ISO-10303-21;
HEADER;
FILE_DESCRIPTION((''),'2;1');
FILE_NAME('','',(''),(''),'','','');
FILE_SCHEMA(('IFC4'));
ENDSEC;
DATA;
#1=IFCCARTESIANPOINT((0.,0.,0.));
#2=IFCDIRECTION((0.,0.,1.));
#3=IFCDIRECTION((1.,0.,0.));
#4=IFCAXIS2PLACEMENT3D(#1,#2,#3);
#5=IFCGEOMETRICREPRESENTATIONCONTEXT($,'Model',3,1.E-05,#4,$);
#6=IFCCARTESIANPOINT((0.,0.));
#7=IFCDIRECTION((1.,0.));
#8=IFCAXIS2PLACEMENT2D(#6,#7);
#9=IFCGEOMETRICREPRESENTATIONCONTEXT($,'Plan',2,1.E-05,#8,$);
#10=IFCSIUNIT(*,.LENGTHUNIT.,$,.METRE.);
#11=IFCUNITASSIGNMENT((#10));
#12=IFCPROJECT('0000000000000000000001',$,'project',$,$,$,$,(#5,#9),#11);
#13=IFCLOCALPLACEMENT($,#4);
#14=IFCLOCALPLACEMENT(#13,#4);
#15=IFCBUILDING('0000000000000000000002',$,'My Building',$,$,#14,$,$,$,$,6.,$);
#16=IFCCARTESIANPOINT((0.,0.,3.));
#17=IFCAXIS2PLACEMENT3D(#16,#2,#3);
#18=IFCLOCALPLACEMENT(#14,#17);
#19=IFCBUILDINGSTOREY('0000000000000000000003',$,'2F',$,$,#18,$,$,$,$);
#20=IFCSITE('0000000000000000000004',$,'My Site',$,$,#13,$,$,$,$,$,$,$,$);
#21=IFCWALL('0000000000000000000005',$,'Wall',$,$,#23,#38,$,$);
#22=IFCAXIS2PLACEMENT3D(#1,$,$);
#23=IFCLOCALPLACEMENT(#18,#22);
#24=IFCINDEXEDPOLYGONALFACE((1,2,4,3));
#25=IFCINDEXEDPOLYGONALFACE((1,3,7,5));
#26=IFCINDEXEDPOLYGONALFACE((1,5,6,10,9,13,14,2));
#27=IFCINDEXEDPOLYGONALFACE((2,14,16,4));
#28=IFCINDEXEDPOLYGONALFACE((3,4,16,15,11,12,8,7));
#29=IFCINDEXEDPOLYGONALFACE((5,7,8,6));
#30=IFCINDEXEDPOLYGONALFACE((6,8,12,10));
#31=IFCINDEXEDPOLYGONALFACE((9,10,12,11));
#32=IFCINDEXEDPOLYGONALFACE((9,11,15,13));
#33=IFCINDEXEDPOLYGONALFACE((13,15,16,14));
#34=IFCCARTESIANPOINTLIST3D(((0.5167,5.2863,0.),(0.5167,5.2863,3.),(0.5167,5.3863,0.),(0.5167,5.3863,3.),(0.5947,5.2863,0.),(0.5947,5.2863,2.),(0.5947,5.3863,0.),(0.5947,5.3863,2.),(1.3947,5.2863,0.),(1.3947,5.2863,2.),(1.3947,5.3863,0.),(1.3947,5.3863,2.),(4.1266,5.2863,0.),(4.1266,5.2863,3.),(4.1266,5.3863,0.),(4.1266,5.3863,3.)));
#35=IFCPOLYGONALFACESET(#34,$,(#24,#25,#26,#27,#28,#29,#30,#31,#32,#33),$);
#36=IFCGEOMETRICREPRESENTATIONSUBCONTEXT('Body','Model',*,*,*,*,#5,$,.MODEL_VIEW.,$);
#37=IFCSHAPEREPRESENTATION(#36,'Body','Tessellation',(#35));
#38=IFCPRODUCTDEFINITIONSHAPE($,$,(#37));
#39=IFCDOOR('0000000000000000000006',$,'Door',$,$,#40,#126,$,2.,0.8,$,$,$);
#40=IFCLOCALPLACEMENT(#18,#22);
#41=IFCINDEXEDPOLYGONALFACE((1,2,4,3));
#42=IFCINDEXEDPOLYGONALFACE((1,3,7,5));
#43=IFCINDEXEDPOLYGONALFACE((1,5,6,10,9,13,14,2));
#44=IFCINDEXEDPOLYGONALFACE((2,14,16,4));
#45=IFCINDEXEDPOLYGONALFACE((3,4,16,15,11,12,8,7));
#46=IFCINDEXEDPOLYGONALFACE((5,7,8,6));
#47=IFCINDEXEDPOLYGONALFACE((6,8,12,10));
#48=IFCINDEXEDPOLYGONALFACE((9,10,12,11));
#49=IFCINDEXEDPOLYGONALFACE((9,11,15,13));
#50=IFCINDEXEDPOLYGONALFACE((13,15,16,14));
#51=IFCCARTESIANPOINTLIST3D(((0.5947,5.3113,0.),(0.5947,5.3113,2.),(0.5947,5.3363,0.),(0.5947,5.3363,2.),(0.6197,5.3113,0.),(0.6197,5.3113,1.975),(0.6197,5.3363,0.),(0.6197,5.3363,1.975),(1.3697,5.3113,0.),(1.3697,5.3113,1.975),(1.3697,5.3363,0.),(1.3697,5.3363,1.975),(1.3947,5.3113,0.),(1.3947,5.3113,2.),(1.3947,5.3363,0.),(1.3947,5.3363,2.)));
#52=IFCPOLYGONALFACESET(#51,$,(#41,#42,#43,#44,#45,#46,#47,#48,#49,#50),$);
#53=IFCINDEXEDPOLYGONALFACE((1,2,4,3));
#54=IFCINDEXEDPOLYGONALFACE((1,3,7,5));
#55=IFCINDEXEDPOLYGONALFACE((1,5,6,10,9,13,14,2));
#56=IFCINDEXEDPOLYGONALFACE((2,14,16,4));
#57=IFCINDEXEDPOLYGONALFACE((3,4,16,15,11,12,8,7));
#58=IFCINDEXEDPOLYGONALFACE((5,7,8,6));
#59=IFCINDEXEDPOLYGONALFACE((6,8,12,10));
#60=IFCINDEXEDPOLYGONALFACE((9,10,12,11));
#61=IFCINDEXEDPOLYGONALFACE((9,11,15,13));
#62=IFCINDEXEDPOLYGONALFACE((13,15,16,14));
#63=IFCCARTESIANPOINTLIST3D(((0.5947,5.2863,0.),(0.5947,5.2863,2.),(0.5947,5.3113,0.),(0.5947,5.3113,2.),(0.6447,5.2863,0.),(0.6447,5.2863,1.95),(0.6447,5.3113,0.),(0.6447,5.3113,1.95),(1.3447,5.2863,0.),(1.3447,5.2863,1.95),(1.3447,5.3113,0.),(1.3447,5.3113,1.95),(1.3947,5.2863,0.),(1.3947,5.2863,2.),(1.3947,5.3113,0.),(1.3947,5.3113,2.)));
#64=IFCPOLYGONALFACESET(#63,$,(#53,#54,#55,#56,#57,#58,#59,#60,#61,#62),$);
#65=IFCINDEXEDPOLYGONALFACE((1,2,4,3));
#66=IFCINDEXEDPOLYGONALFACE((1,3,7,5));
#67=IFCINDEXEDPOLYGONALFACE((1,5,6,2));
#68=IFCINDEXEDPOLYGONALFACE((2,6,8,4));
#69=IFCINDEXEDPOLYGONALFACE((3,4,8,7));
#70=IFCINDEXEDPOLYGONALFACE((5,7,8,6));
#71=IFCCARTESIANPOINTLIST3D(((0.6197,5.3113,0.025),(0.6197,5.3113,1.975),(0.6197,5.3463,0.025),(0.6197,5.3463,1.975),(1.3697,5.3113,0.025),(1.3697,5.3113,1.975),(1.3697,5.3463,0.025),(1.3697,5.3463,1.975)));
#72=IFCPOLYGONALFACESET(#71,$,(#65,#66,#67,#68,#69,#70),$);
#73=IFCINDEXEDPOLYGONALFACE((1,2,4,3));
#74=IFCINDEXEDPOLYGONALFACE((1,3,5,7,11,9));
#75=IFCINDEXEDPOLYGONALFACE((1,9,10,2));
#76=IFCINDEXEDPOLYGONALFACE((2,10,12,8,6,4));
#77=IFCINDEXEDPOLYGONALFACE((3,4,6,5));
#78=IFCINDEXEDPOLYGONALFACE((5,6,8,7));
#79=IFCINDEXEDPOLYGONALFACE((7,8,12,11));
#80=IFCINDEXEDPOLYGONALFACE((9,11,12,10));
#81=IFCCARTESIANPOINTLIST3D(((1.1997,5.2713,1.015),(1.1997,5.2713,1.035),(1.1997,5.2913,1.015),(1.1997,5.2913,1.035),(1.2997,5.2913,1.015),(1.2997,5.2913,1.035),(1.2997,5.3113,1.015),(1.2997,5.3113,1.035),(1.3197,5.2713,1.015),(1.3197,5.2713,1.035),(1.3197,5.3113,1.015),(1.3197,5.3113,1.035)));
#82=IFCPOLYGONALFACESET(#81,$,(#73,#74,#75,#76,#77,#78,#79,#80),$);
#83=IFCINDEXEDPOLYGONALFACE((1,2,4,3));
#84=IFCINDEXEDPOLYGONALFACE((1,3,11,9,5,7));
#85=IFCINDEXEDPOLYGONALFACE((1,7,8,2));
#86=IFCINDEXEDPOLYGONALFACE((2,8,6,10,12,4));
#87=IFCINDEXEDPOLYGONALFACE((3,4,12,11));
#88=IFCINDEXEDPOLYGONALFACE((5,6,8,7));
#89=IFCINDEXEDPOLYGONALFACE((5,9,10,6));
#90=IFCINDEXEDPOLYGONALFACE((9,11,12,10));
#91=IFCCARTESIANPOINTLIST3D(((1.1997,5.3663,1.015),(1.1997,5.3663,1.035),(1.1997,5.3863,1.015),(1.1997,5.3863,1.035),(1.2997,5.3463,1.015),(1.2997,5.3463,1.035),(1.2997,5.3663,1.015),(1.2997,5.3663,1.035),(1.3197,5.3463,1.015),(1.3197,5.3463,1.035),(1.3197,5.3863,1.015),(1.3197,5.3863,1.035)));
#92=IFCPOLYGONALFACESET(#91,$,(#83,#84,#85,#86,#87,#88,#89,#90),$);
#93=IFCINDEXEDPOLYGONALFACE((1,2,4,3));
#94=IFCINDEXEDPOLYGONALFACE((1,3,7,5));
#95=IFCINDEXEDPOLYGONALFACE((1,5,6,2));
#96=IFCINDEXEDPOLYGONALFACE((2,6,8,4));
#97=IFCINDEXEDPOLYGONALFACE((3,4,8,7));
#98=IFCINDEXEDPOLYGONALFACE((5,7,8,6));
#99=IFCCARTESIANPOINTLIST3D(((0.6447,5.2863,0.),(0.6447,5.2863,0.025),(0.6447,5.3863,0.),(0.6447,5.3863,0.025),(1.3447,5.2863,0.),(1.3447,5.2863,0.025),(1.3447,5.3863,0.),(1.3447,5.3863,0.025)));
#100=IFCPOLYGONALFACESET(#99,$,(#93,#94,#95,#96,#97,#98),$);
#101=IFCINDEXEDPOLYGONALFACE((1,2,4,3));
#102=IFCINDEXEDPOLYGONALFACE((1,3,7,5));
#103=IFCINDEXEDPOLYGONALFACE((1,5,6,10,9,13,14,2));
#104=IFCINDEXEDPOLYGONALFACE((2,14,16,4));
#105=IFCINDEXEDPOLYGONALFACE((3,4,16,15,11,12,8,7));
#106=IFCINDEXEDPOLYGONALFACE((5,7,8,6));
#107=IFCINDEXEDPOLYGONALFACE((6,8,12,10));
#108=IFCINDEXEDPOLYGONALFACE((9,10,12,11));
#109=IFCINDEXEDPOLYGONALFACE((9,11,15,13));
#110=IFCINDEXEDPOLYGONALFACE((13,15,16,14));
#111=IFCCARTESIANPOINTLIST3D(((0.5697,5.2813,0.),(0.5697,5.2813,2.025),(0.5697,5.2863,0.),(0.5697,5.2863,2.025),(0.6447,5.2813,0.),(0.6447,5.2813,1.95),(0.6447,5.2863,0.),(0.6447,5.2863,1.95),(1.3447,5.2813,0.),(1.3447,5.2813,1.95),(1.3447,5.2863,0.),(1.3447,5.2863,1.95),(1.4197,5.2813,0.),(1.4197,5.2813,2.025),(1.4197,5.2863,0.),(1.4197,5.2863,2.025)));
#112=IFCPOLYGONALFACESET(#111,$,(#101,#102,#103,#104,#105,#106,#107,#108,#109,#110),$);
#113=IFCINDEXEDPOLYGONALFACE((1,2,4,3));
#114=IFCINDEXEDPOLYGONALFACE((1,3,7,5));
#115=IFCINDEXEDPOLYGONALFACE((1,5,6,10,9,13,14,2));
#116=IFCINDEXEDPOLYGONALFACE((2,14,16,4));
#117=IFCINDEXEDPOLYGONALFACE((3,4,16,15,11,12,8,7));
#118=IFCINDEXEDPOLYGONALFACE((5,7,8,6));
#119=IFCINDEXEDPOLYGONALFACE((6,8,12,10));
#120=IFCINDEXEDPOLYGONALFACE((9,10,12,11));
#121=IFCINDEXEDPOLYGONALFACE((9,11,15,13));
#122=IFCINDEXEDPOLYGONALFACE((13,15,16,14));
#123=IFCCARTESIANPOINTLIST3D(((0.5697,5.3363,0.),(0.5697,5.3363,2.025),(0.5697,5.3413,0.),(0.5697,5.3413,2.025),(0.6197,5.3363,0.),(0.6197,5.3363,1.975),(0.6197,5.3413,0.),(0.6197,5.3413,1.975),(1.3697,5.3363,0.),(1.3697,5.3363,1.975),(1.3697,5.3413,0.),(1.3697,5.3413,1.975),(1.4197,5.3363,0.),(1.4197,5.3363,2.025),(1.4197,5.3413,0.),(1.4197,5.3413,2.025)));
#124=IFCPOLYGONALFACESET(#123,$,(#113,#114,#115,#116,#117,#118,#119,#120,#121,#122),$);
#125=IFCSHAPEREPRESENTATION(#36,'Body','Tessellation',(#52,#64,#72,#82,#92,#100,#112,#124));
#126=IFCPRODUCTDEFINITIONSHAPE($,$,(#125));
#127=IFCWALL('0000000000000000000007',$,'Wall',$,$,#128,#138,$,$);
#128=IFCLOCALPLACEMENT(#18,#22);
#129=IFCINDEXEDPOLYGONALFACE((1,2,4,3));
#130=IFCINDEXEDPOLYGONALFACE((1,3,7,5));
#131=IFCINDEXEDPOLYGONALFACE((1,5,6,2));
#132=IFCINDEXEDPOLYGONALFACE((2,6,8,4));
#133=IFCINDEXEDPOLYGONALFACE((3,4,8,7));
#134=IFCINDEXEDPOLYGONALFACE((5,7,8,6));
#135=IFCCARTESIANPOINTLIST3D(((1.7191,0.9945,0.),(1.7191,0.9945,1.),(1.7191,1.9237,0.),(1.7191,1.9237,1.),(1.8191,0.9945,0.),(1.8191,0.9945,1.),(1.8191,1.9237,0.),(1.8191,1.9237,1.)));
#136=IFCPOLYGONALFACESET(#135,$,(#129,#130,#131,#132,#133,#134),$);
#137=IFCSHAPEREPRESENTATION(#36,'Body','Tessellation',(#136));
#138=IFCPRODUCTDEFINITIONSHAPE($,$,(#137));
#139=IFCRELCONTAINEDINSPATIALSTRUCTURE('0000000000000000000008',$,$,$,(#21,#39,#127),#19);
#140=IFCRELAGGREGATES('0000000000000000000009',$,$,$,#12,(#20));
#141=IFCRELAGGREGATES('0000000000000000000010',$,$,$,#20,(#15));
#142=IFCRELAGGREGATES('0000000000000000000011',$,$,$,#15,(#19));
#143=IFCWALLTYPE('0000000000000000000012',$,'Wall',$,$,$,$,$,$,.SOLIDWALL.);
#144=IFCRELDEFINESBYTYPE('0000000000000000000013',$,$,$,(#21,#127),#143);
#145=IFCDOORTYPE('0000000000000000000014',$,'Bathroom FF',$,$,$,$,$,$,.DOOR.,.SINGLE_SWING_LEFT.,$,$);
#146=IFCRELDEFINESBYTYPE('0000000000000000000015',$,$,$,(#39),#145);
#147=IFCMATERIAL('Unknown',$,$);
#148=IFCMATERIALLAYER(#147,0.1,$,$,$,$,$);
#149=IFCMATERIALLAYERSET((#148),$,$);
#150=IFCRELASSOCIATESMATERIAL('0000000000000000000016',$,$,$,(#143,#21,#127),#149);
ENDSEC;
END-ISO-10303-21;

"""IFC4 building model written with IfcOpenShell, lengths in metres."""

from ifc_helpers import new_model, entity, si_unit, frame, origin_with_axes, origin_2d_with_axis, place, context, subcontext, project, spatial, line, indexed_curve, outline, extrude, shape, source, transform, mapped, material, layer, layer_set, layer_usage, type_object, type_shapes, element, fill, save


model = new_model("IFC4")

# Units and contexts
model_context = context("Model", 3, precision=1e-05, world=origin_with_axes())
plan_context = context("Plan", 2, precision=1e-05, world=origin_2d_with_axis())
body_context_1 = subcontext(model_context, "Body", "Model", "MODEL_VIEW")
body_context_2 = subcontext(plan_context, "Body", "Plan", "PLAN_VIEW")
ifc_project = project(units=[si_unit("LENGTHUNIT", "METRE")], contexts=[model_context, plan_context])

# Site, building, storey
site_placement = place(None, origin_with_axes())
site = spatial("IfcSite", under=ifc_project, at=site_placement, Name="My Site")
building_placement = place(site_placement, origin_with_axes())
building = spatial("IfcBuilding", under=site, at=building_placement, Name="My Building", ElevationOfTerrain=6.0)
storey_placement = place(building_placement, frame((0.0, 0.0, 3.0), z_axis=(0.0, 0.0, 1.0), x_axis=(1.0, 0.0, 0.0)))
storey = spatial("IfcBuildingStorey", under=building, at=storey_placement, Name="2F")

# Shared definitions
ifc_material = material(Name="Unknown")

# Shared definitions
ifc_layer_1 = layer(ifc_material, 0.1)
ifc_layer_set_1 = layer_set([ifc_layer_1])
wall_type = type_object("IfcWallType", Name="Wall", PredefinedType="SOLIDWALL", material=ifc_layer_set_1)

# Shared definitions
shared_shape_1 = source(origin_with_axes(), body_context_1, "Body", "SweptSolid", [
    extrude(outline(indexed_curve([(0.0, 0.0), (0.8, 0.0), (0.8, 2.0), (0.0, 2.0)], segments=[line(1, 2, 3, 4, 1)])), frame((0.0, -0.6, 0.0), z_axis=(0.0, -1.0, 0.0), x_axis=(1.0, 0.0, 0.0)), (0.0, 0.0, -1.0), 1.2),
])
door_type_1 = type_object("IfcDoorType", Name="Bathroom FF", OperationType="SINGLE_SWING_LEFT", PredefinedType="DOOR")
shared_shape_2 = source(origin_with_axes(), body_context_1, "Body", "SweptSolid", [
    extrude(outline(indexed_curve([(0.0, 0.0), (0.0, 2.0), (0.8, 2.0), (0.8, 0.0), (0.775, 0.0), (0.775, 1.975), (0.025, 1.975), (0.025, 0.0)], segments=[line(1, 2, 3, 4, 5, 6, 7, 8, 1)])), frame((0.0, 0.025, 0.0), z_axis=(0.0, -1.0, 0.0), x_axis=(1.0, 0.0, 0.0)), (0.0, 0.0, -1.0), 0.025),
    extrude(outline(indexed_curve([(0.0, 0.0), (0.0, 2.0), (0.8, 2.0), (0.8, 0.0), (0.75, 0.0), (0.75, 1.95), (0.05, 1.95), (0.05, 0.0)], segments=[line(1, 2, 3, 4, 5, 6, 7, 8, 1)])), frame((0.0, 0.0, 0.0), z_axis=(0.0, -1.0, 0.0), x_axis=(1.0, 0.0, 0.0)), (0.0, 0.0, -1.0), 0.025),
    extrude(outline(indexed_curve([(0.0, 0.0), (0.75, 0.0), (0.75, 0.035), (0.0, 0.035)], segments=[line(1, 2, 3, 4, 1)])), frame((0.025, 0.025, 0.025), z_axis=(0.0, 0.0, 1.0), x_axis=(1.0, 0.0, 0.0)), (0.0, 0.0, 1.0), 1.95),
    extrude(outline(indexed_curve([(0.0, 0.0), (0.0, -0.04), (-0.12, -0.04), (-0.12, -0.02), (-0.02, -0.02), (-0.02, 0.0)], segments=[line(1, 2, 3, 4, 5, 6, 1)])), frame((0.725, 0.025, 1.015), z_axis=(0.0, 0.0, 1.0), x_axis=(1.0, 0.0, 0.0)), (0.0, 0.0, 1.0), 0.02),
    extrude(outline(indexed_curve([(0.0, 0.0), (0.0, 0.04), (-0.12, 0.04), (-0.12, 0.02), (-0.02, 0.02), (-0.02, 0.0)], segments=[line(1, 2, 3, 4, 5, 6, 1)])), frame((0.725, 0.06, 1.015), z_axis=(0.0, 0.0, 1.0), x_axis=(1.0, 0.0, 0.0)), (0.0, 0.0, 1.0), 0.02),
    extrude(outline(indexed_curve([(0.0, 0.0), (0.7, 0.0), (0.7, 0.1), (0.0, 0.1)], segments=[line(1, 2, 3, 4, 1)])), frame((0.05, 0.0, 0.0), z_axis=(0.0, 0.0, 1.0), x_axis=(1.0, 0.0, 0.0)), (0.0, 0.0, 1.0), 0.025),
    extrude(outline(indexed_curve([(0.0, 0.0), (0.0, 2.025), (0.85, 2.025), (0.85, 0.0), (0.775, 0.0), (0.775, 1.95), (0.075, 1.95), (0.075, 0.0)], segments=[line(1, 2, 3, 4, 5, 6, 7, 8, 1)])), frame((-0.025, -0.005, 0.0), z_axis=(0.0, -1.0, 0.0), x_axis=(1.0, 0.0, 0.0)), (0.0, 0.0, -1.0), 0.005),
    extrude(outline(indexed_curve([(0.0, 0.0), (0.0, 2.025), (0.85, 2.025), (0.85, 0.0), (0.8, 0.0), (0.8, 1.975), (0.05, 1.975), (0.05, 0.0)], segments=[line(1, 2, 3, 4, 5, 6, 7, 8, 1)])), frame((-0.025, 0.05, 0.0), z_axis=(0.0, -1.0, 0.0), x_axis=(1.0, 0.0, 0.0)), (0.0, 0.0, -1.0), 0.005),
])
shared_shape_3 = source(origin_with_axes(), body_context_2, "Body", "Curve2D", [
    entity("IfcIndexedPolyCurve", entity("IfcCartesianPointList2D", [[0.0, 0.0], [0.0, 0.05], [0.025, 0.05], [0.025, 0.025], [0.05, 0.025], [0.05, 0.0]]), [entity("IfcLineIndex", [1, 2, 3, 4, 5, 6, 1])]),
    entity("IfcIndexedPolyCurve", entity("IfcCartesianPointList2D", [[0.8, 0.0], [0.8, 0.05], [0.775, 0.05], [0.775, 0.025], [0.75, 0.025], [0.75, 0.0]]), [entity("IfcLineIndex", [1, 2, 3, 4, 5, 6, 1])]),
    entity("IfcTrimmedCurve", entity("IfcEllipse", entity("IfcAxis2Placement2D", entity("IfcCartesianPoint", [0.06, 0.05]), entity("IfcDirection", [1.0, 0.0])), 0.715, 0.75), [entity("IfcCartesianPoint", [0.775, 0.05])], [entity("IfcCartesianPoint", [0.06, 0.8])], True, "CARTESIAN"),
    entity("IfcIndexedPolyCurve", entity("IfcCartesianPointList2D", [[0.025, 0.05], [0.06, 0.05], [0.06, 0.8], [0.025, 0.8]]), [entity("IfcLineIndex", [1, 2, 3, 4, 1])]),
])
type_shapes(door_type_1, [shared_shape_2, shared_shape_3])

# Wall, opening, door
ifc_layer_usage_1 = layer_usage(ifc_layer_set_1, "AXIS2", "POSITIVE", 0.0)
wall_1_placement = place(storey_placement, frame((4.1266, 5.3863, 0.0), z_axis=(0.0, 0.0, 1.0), x_axis=(-1.0, 0.0, 0.0)))
wall_1 = element("IfcWall", 1, at=wall_1_placement, inside=storey, type_object=wall_type, material=ifc_layer_usage_1, Name="Wall", context=body_context_1, shape_type="SweptSolid", body=[
    extrude(outline(indexed_curve([(0.0, 0.0), (0.0, 0.1), (3.6099, 0.1), (3.6099, 0.0)], segments=[line(1, 2, 3, 4, 1)])), origin_with_axes(), (0.0, 0.0, 1.0), 3.0),
])
opening_1_placement = place(wall_1_placement, frame((3.5319, 0.1, 0.0), z_axis=(0.0, 0.0, 1.0), x_axis=(-1.0, 0.0, 0.0)))
opening_1 = element("IfcOpeningElement", 2, at=opening_1_placement, cuts=wall_1, PredefinedType="OPENING", context=body_context_1, shape_type="MappedRepresentation", body=[
    mapped(shared_shape_1, transform((0.0, 0.0, 0.0), x_axis=(1.0, 0.0, 0.0), y_axis=(0.0, 1.0, 0.0), z_axis=(0.0, 0.0, 1.0), scale=1.0)),
])
door_1_placement = place(opening_1_placement, origin_with_axes())
door_1 = element("IfcDoor", 3, at=door_1_placement, inside=storey, type_object=door_type_1, Name="Door", OverallHeight=2.0, OverallWidth=0.8, shapes=[
    shape(body_context_1, "Body", "MappedRepresentation", [mapped(shared_shape_2, transform((0.0, 0.0, 0.0), x_axis=(1.0, 0.0, 0.0), y_axis=(0.0, 1.0, 0.0), z_axis=(0.0, 0.0, 1.0), scale=1.0))]),
    shape(body_context_2, "Body", "MappedRepresentation", [mapped(shared_shape_3, transform((0.0, 0.0, 0.0), x_axis=(1.0, 0.0, 0.0), y_axis=(0.0, 1.0, 0.0), z_axis=(0.0, 0.0, 1.0), scale=1.0))]),
])
fill(opening_1, door_1)

# Wall
ifc_layer_usage_2 = layer_usage(ifc_layer_set_1, "AXIS2", "POSITIVE", 0.0)
wall_2_placement = place(storey_placement, frame((1.8191, 0.9945, 0.0), z_axis=(0.0, 0.0, 1.0), x_axis=(0.0, 1.0, 0.0)))
element("IfcWall", 4, at=wall_2_placement, inside=storey, type_object=wall_type, material=ifc_layer_usage_2, Name="Wall", context=body_context_1, shape_type="SweptSolid", body=[
    extrude(outline(indexed_curve([(0.0, 0.0), (0.0, 0.1), (0.9291, 0.1), (0.9291, 0.0)], segments=[line(1, 2, 3, 4, 1)])), origin_with_axes(), (0.0, 0.0, 1.0), 1.0),
])

save(model, "model.ifc")
